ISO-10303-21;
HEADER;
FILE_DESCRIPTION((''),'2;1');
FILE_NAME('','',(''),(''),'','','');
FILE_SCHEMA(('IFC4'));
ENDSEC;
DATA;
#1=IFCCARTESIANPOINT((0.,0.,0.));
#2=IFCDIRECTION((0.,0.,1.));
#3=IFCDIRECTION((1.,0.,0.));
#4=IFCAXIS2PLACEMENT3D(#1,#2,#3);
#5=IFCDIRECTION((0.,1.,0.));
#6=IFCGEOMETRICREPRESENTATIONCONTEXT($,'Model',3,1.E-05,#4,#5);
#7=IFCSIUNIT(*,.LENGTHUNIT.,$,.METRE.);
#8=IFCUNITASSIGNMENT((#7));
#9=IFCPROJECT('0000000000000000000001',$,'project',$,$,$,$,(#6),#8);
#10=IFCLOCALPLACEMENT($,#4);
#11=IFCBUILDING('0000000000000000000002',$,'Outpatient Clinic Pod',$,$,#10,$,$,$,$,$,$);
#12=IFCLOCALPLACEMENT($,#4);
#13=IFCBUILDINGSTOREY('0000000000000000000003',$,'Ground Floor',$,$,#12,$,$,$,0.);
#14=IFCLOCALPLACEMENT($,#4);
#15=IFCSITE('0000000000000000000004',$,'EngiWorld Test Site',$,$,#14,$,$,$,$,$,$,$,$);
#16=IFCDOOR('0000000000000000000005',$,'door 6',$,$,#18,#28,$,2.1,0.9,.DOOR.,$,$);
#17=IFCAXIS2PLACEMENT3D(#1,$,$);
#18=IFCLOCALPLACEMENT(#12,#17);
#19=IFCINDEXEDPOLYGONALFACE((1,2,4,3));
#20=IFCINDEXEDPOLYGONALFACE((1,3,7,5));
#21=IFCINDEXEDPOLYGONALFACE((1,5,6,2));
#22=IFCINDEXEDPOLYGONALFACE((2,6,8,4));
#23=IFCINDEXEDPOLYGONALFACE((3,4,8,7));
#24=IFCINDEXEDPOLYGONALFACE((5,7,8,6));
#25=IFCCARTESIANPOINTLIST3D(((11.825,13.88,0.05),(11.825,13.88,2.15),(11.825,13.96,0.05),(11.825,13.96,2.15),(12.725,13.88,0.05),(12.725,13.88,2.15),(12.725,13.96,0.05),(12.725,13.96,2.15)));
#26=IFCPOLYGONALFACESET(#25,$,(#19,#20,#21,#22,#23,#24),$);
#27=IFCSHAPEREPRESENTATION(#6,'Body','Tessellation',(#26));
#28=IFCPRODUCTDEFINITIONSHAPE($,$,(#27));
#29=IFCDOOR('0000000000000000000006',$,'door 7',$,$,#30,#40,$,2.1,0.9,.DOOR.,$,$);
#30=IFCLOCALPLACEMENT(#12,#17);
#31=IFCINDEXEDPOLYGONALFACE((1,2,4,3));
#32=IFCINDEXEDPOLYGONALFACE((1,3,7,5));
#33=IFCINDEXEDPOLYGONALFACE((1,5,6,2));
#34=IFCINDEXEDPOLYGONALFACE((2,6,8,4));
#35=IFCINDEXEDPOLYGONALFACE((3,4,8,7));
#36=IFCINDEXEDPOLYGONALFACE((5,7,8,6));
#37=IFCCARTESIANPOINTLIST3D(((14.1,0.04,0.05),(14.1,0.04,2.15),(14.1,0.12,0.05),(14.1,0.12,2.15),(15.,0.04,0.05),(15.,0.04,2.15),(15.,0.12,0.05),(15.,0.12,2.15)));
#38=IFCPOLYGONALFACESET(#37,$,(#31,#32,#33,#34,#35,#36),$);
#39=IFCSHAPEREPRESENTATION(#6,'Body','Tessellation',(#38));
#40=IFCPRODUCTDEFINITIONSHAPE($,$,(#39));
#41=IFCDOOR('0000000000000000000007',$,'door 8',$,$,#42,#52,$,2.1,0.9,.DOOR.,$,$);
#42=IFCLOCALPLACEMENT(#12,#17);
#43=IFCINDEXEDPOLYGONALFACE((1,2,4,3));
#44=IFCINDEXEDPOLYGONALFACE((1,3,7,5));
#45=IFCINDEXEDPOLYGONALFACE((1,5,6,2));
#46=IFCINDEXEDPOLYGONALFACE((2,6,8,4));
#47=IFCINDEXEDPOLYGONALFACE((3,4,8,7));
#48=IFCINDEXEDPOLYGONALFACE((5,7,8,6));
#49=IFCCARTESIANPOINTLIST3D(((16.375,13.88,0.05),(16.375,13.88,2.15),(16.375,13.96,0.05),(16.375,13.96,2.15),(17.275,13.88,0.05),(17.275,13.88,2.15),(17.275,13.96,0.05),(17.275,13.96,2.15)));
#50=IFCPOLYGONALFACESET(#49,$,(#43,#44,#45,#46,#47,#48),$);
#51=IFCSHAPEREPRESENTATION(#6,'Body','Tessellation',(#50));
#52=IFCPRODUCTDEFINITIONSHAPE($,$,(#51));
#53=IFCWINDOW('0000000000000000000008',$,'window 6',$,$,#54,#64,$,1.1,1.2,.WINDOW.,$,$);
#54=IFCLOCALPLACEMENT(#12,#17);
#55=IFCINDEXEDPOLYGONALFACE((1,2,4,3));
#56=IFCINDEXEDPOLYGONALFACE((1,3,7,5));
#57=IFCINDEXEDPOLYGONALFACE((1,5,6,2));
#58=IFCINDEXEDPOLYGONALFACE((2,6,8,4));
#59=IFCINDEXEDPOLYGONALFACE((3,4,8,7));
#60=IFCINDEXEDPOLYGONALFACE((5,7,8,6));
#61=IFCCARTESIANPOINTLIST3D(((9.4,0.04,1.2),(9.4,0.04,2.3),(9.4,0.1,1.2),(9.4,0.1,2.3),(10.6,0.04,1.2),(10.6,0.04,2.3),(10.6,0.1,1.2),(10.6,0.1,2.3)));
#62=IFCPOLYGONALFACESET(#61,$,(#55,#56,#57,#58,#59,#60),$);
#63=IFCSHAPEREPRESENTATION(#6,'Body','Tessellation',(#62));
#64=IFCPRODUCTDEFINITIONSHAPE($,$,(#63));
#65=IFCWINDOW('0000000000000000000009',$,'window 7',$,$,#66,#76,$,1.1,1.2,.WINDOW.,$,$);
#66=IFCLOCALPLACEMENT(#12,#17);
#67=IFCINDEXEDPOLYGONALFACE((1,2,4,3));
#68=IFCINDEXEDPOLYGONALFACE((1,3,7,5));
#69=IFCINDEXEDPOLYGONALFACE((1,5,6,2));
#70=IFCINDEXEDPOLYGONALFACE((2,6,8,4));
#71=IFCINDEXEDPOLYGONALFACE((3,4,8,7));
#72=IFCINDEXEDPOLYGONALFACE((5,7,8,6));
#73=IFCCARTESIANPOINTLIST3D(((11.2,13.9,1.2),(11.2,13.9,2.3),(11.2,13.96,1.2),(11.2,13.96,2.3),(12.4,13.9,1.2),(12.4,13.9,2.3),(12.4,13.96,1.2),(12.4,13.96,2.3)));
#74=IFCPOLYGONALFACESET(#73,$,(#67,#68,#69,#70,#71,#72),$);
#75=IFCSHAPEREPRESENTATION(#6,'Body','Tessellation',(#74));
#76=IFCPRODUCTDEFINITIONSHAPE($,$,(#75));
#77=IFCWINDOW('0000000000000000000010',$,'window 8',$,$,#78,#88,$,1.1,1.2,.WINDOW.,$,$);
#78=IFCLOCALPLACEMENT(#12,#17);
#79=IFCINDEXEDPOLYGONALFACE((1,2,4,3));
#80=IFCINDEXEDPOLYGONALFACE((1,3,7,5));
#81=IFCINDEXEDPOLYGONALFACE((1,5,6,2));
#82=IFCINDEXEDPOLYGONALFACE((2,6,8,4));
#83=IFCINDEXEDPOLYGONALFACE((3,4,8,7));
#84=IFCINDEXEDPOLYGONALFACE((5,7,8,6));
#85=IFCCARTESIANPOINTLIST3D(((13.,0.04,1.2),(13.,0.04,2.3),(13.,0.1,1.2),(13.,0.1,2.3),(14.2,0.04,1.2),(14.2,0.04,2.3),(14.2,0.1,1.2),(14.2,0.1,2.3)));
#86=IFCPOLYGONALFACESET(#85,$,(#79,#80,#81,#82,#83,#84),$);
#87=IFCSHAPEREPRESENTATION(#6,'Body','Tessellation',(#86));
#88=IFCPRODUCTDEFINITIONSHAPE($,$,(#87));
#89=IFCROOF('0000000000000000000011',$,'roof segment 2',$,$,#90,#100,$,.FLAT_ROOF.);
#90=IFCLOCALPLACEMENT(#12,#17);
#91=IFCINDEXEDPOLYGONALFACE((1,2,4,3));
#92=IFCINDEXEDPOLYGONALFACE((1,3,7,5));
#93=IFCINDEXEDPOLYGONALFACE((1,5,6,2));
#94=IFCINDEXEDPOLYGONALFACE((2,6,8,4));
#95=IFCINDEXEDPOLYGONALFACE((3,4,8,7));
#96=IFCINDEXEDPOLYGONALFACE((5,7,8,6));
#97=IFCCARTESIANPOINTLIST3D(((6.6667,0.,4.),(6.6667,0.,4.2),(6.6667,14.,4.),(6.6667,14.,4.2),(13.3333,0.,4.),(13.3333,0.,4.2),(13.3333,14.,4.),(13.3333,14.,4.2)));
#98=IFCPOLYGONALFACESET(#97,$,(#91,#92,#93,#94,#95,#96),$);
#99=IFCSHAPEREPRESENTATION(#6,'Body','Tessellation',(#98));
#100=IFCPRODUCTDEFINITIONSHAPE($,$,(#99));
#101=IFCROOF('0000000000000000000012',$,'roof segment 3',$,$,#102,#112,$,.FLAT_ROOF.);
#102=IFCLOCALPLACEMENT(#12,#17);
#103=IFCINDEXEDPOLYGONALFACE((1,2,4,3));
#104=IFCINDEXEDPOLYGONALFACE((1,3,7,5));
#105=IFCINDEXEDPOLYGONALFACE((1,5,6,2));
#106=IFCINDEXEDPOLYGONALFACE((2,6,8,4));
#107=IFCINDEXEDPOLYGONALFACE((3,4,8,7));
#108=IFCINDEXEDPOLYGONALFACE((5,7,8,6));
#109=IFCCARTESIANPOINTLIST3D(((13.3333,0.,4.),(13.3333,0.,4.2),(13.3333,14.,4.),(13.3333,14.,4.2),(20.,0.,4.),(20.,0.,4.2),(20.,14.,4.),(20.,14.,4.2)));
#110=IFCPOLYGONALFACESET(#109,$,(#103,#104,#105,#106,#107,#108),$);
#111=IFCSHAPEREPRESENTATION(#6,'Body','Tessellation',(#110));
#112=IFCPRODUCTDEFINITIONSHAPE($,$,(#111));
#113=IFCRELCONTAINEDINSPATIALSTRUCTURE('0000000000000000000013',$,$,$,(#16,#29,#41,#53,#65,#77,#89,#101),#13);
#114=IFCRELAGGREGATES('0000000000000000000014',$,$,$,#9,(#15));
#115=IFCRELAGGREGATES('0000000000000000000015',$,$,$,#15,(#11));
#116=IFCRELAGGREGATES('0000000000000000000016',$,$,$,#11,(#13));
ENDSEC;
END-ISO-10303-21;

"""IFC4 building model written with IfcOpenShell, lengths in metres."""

from ifc_helpers import new_model, si_unit, direction, frame, origin_with_axes, origin_2d_with_axis, place, context, project, spatial, rectangle, extrude, element, save


model = new_model("IFC4")

# Units and contexts
model_context = context("Model", 3, precision=1e-05, world=origin_with_axes(), true_north=direction((0.0, 1.0, 0.0)))
ifc_project = project(units=[si_unit("LENGTHUNIT", "METRE")], contexts=[model_context])

# Site, building, storey
site_placement = place(None, origin_with_axes())
site = spatial("IfcSite", under=ifc_project, at=site_placement, Name="EngiWorld Test Site")
building_placement = place(None, origin_with_axes())
building = spatial("IfcBuilding", under=site, at=building_placement, Name="Outpatient Clinic Pod")
storey_placement = place(None, origin_with_axes())
storey = spatial("IfcBuildingStorey", under=building, at=storey_placement, Name="Ground Floor", Elevation=0.0)

# Doors
for number, where, z_axis, x_axis, name in (
    (1, (12.275, 13.92, 0.05), (0.0, 0.0, 1.0), (1.0, 0.0, 0.0), "door 6"),
    (2, (14.55, 0.08, 0.05), (0.0, 0.0, 1.0), (1.0, 0.0, 0.0), "door 7"),
    (3, (16.825, 13.92, 0.05), (0.0, 0.0, 1.0), (1.0, 0.0, 0.0), "door 8"),
):
    element("IfcDoor", number, at=place(None, frame(where, z_axis=z_axis, x_axis=x_axis)), inside=storey, Name=name, OverallHeight=2.1, OverallWidth=0.9, PredefinedType="DOOR", context=model_context, shape_type="SweptSolid", body=[
        extrude(rectangle(XDim=0.9, YDim=0.08, at=origin_2d_with_axis()), origin_with_axes(), (0.0, 0.0, 1.0), 2.1),
    ])

# Windows
for number, where, z_axis, x_axis, name in (
    (4, (10.0, 0.07, 1.2), (0.0, 0.0, 1.0), (1.0, 0.0, 0.0), "window 6"),
    (5, (11.8, 13.93, 1.2), (0.0, 0.0, 1.0), (1.0, 0.0, 0.0), "window 7"),
    (6, (13.6, 0.07, 1.2), (0.0, 0.0, 1.0), (1.0, 0.0, 0.0), "window 8"),
):
    element("IfcWindow", number, at=place(None, frame(where, z_axis=z_axis, x_axis=x_axis)), inside=storey, Name=name, OverallHeight=1.1, OverallWidth=1.2, PredefinedType="WINDOW", context=model_context, shape_type="SweptSolid", body=[
        extrude(rectangle(XDim=1.2, YDim=0.06, at=origin_2d_with_axis()), origin_with_axes(), (0.0, 0.0, 1.0), 1.1),
    ])

# Roofs
for number, where, z_axis, x_axis, name in (
    (7, (10.0, 7.0, 4.0), (0.0, 0.0, 1.0), (1.0, 0.0, 0.0), "roof segment 2"),
    (8, (16.6667, 7.0, 4.0), (0.0, 0.0, 1.0), (1.0, 0.0, 0.0), "roof segment 3"),
):
    element("IfcRoof", number, at=place(None, frame(where, z_axis=z_axis, x_axis=x_axis)), inside=storey, Name=name, PredefinedType="FLAT_ROOF", context=model_context, shape_type="SweptSolid", body=[
        extrude(rectangle(XDim=6.6667, YDim=14.0, at=origin_2d_with_axis()), origin_with_axes(), (0.0, 0.0, 1.0), 0.2),
    ])

save(model, "model.ifc")
